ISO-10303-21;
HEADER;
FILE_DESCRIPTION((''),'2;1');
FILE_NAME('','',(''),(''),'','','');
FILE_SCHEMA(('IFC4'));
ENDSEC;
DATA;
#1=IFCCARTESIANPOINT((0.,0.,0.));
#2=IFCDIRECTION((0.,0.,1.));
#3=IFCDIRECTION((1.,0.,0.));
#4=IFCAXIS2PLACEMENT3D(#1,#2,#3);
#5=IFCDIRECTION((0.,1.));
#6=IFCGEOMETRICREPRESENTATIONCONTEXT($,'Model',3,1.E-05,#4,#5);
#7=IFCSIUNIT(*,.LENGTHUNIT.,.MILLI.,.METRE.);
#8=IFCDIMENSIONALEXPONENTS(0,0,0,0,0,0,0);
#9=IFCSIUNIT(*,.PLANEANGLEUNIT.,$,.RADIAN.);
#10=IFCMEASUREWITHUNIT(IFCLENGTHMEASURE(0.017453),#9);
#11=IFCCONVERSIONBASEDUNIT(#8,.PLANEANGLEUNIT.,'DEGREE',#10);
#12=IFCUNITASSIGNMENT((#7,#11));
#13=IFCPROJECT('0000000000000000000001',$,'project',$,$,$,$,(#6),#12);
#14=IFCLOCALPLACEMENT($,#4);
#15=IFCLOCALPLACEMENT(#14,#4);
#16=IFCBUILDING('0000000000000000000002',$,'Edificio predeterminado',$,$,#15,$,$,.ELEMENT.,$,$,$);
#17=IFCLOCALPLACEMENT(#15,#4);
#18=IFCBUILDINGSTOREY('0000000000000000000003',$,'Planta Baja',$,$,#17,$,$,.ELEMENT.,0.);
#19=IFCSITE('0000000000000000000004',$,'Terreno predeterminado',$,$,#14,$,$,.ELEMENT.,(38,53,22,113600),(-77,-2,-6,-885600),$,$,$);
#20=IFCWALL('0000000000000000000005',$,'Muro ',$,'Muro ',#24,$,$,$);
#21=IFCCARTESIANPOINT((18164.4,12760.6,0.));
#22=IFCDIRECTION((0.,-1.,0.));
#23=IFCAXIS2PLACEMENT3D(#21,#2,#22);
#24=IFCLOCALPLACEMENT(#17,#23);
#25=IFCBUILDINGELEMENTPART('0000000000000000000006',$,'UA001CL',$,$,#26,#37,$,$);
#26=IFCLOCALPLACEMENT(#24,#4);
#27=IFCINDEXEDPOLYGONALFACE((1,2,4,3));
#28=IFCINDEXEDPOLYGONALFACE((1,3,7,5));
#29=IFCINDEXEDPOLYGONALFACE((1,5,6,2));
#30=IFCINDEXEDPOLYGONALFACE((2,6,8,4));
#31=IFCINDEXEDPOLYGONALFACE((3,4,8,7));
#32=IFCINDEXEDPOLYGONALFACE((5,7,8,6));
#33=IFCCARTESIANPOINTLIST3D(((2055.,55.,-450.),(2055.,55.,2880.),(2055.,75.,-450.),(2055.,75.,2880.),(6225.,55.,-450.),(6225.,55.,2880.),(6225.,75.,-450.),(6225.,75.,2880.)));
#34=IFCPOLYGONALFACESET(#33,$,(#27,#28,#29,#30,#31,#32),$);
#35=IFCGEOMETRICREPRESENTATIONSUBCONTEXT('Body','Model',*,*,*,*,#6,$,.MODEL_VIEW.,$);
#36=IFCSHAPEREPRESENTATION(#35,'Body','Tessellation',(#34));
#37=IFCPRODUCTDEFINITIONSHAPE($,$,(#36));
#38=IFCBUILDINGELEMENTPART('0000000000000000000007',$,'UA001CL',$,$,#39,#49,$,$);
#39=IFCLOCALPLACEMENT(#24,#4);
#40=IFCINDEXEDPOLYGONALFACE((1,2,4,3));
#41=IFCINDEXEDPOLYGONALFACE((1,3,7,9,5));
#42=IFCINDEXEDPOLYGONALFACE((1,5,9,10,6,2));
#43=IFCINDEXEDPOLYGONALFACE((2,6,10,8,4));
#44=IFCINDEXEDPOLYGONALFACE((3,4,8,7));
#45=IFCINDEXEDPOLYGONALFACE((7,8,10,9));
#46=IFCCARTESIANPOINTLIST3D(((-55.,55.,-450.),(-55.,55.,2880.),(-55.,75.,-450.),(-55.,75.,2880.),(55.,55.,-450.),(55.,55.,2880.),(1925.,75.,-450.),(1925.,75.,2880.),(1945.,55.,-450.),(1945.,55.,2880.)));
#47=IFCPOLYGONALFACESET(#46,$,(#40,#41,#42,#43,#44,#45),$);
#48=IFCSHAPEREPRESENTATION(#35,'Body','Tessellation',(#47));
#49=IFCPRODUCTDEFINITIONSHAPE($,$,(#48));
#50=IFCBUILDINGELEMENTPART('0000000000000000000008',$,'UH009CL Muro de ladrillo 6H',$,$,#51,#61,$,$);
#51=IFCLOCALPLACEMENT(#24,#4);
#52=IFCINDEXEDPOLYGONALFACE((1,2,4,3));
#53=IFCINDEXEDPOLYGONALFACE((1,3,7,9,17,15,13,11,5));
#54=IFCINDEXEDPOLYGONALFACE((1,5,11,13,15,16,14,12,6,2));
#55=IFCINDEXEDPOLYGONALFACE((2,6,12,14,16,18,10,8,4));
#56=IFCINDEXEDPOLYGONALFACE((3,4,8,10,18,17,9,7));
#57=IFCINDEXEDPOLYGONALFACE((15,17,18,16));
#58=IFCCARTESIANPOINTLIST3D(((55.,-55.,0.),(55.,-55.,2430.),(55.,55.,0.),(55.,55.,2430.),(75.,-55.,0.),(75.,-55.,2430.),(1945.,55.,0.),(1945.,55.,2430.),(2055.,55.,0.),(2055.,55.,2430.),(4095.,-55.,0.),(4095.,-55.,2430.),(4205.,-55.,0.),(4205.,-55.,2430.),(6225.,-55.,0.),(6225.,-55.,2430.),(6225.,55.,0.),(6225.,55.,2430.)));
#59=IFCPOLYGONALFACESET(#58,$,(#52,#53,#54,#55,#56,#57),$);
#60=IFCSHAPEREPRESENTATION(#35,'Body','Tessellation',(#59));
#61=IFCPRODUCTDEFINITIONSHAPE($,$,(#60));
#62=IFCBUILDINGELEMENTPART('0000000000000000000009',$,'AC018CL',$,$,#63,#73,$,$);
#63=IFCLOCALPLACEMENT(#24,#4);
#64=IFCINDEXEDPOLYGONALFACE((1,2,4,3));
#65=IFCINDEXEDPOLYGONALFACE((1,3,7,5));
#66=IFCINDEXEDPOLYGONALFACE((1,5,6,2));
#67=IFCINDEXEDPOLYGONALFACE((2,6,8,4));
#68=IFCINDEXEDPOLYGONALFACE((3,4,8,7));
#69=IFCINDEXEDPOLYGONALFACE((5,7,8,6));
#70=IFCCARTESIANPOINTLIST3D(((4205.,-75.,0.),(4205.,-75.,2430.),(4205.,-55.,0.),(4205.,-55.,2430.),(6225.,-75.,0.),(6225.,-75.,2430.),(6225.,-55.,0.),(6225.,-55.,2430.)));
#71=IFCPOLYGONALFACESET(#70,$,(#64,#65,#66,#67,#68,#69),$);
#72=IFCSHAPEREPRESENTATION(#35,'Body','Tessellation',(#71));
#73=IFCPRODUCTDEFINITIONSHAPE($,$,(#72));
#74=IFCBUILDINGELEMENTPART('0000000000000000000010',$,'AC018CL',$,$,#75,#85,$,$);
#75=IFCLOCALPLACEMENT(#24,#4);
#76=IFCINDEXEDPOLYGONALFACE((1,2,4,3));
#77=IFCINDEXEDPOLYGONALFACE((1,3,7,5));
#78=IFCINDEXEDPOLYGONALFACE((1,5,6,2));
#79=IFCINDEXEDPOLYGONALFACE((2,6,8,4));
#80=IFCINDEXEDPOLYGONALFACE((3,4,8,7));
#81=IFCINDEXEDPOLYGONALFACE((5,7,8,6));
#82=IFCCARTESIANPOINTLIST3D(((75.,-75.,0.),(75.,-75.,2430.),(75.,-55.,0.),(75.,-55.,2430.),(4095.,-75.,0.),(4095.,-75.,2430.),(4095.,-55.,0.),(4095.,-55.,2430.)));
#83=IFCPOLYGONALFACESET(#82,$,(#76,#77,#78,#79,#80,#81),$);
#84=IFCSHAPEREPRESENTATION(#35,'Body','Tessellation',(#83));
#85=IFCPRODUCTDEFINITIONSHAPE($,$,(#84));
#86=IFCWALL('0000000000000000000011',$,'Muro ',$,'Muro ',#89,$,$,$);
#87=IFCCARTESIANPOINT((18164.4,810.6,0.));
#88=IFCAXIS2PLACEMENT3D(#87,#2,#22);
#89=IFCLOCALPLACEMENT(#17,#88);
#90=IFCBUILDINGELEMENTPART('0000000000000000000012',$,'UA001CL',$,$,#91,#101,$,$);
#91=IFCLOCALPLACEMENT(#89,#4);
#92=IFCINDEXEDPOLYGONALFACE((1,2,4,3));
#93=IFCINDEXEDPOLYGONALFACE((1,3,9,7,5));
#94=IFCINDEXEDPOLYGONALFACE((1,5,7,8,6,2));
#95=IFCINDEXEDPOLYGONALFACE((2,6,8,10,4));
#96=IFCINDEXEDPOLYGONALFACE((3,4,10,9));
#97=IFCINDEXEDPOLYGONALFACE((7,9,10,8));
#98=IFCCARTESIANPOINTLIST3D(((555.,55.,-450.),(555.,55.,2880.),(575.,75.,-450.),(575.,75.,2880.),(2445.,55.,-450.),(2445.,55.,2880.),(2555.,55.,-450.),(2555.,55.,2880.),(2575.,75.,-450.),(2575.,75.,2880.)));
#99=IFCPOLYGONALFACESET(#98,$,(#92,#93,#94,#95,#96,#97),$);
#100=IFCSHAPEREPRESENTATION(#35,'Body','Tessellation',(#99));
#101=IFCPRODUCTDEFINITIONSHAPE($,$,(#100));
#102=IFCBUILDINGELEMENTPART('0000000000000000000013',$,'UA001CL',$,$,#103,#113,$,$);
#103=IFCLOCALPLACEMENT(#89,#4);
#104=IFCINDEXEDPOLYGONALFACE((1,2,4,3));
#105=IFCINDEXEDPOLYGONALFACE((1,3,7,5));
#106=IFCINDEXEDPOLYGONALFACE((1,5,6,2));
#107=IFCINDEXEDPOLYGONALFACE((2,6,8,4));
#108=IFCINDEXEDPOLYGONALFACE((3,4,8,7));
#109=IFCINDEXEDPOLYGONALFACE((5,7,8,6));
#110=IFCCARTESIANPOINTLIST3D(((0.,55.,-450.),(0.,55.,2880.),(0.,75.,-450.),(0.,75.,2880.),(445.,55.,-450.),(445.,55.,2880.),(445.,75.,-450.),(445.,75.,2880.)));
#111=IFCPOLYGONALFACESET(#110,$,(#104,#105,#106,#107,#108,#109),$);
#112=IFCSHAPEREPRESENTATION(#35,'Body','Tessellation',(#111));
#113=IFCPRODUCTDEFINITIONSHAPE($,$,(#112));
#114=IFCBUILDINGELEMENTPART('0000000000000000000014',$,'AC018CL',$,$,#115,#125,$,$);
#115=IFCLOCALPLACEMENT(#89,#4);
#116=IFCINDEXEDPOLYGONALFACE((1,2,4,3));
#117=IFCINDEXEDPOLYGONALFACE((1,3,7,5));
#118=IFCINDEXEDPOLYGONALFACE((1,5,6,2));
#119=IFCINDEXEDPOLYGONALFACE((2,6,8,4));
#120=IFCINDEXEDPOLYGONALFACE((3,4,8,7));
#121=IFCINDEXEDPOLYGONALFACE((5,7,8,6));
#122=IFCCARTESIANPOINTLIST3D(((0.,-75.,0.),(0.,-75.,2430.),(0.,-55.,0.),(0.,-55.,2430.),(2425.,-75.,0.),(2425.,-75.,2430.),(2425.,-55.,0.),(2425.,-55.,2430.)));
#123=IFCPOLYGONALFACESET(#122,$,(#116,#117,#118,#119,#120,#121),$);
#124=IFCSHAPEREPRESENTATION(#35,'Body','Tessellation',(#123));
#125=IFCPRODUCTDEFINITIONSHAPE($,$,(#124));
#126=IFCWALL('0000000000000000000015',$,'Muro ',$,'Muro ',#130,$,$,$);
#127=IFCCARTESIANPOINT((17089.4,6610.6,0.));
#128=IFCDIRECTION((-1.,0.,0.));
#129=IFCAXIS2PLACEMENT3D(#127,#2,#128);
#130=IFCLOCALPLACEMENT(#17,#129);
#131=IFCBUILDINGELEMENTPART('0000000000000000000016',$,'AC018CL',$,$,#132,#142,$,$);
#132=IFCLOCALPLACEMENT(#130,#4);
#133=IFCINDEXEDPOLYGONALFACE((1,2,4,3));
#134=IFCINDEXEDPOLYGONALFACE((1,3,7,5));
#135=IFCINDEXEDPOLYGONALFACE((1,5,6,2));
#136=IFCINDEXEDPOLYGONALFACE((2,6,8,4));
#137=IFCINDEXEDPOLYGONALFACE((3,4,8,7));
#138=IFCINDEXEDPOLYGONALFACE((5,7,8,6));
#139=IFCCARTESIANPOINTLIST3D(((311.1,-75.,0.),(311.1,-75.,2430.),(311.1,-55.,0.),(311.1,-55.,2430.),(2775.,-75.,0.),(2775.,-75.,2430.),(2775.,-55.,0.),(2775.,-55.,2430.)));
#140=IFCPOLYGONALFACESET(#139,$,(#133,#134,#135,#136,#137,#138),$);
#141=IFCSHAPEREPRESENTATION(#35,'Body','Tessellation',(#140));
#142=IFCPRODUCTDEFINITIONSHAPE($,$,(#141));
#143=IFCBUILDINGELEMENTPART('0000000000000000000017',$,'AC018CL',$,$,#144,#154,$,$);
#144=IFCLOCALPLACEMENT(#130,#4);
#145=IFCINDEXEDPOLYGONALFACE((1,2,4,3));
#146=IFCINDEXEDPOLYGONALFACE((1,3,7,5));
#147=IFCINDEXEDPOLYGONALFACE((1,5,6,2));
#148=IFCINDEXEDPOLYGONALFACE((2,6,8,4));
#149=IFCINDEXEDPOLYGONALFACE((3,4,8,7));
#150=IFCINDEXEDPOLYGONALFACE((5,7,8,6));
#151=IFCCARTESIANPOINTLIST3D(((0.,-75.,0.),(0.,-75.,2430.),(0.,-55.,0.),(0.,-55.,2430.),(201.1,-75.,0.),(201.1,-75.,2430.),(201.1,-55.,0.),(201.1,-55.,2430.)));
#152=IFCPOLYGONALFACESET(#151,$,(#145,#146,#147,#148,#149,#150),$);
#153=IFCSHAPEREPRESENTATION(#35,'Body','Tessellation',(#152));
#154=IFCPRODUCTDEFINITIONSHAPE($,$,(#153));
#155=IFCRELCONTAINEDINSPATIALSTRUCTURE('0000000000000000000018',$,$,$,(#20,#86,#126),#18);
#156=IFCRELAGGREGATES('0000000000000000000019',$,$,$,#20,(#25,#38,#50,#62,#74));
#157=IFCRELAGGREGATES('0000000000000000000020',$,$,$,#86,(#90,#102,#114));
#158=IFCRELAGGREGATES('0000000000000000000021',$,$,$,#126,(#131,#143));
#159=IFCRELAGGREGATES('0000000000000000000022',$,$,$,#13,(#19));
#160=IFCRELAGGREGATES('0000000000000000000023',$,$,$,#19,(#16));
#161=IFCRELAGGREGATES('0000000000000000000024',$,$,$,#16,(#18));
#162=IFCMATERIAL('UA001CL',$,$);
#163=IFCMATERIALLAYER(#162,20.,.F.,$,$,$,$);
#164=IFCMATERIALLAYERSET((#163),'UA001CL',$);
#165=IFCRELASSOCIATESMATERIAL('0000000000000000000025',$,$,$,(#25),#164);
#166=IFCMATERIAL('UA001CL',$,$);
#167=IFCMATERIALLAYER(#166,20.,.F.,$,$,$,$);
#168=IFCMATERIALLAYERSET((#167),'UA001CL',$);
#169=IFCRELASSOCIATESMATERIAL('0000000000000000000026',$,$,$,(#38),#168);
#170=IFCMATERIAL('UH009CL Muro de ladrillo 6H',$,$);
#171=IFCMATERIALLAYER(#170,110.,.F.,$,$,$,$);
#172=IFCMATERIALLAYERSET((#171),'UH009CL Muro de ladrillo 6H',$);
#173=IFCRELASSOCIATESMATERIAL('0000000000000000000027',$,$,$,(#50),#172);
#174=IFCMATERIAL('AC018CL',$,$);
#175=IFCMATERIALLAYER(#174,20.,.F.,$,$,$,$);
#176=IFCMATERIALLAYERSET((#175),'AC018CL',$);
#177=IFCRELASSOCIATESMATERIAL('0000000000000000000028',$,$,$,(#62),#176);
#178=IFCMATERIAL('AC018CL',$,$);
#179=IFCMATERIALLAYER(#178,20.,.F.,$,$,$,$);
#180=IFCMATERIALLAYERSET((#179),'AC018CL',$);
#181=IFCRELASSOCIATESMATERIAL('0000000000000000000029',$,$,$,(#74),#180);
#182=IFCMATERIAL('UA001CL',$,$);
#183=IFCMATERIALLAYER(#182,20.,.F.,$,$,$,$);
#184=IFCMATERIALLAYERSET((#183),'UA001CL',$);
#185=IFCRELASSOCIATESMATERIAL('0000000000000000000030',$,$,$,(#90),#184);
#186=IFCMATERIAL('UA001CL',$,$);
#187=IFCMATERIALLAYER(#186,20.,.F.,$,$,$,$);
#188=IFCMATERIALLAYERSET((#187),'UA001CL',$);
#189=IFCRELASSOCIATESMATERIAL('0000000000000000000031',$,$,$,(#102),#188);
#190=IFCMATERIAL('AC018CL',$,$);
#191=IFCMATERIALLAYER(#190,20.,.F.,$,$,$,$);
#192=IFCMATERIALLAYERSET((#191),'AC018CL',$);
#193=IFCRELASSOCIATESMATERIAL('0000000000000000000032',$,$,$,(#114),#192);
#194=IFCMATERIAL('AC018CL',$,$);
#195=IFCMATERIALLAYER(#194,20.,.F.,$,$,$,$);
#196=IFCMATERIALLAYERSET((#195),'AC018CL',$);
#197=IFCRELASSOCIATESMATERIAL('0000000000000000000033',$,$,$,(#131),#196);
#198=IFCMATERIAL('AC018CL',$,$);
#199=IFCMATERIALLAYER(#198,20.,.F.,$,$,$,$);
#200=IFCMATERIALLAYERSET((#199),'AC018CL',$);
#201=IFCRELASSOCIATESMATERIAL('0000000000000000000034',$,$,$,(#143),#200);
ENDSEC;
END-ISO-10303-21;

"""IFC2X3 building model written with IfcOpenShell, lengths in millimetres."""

from ifc_helpers import new_model, entity, si_unit, converted_unit, direction, frame, origin_with_axes, place, context, subcontext, project, spatial, polyline, outline, extrude, material, layer, layer_set, layer_usage, element, aggregate, save


model = new_model("IFC2X3")

# Units and contexts
model_context = context("Model", 3, precision=1e-05, world=origin_with_axes(), true_north=direction((0.0, 1.0)))
body_context = subcontext(model_context, "Body", "Model", "MODEL_VIEW")
ifc_project = project(units=[si_unit("LENGTHUNIT", "METRE", prefix="MILLI"), converted_unit("PLANEANGLEUNIT", "DEGREE", entity("IfcLengthMeasure", 0.017453), si_unit("PLANEANGLEUNIT", "RADIAN"), dimensions=[0, 0, 0, 0, 0, 0, 0])], contexts=[model_context])

# Site, building, storey
site_placement = place(None, origin_with_axes())
site = spatial("IfcSite", under=ifc_project, at=site_placement, Name="Terreno predeterminado", CompositionType="ELEMENT", RefLatitude=(38, 53, 22, 113600), RefLongitude=(-77, -2, -6, -885600))
building_placement = place(site_placement, origin_with_axes())
building = spatial("IfcBuilding", under=site, at=building_placement, Name="Edificio predeterminado", CompositionType="ELEMENT")
storey_placement = place(building_placement, origin_with_axes())
storey = spatial("IfcBuildingStorey", under=building, at=storey_placement, Name="Planta Baja", CompositionType="ELEMENT", Elevation=0.0)

# Walls, building element parts
wall_1_placement = place(storey_placement, frame((18164.4, 12760.6, 0.0), z_axis=(0.0, 0.0, 1.0), x_axis=(0.0, -1.0, 0.0)))
wall_1 = element("IfcWall", 1, at=wall_1_placement, inside=storey, Name="Muro ", ObjectType="Muro ")
ifc_material_1 = material(Name="UA001CL")
ifc_layer_1 = layer(ifc_material_1, 20.0, ventilated=False)
ifc_layer_set_1 = layer_set([ifc_layer_1], Name="UA001CL")
ifc_layer_usage_1 = layer_usage(ifc_layer_set_1, "AXIS2", "NEGATIVE", -75.0)
building_element_part_1_placement = place(wall_1_placement, origin_with_axes())
building_element_part_1 = element("IfcBuildingElementPart", 2, at=building_element_part_1_placement, material=ifc_layer_usage_1, Name="UA001CL", context=body_context, shape_type="SweptSolid", body=[
    extrude(outline(polyline([(6225.0, 75.0), (6225.0, 55.0), (2055.0, 55.0), (2055.0, 75.0), (6225.0, 75.0)])), frame((0.0, 0.0, -450.0), z_axis=(0.0, 0.0, 1.0), x_axis=(1.0, 0.0, 0.0)), (0.0, 0.0, 1.0), 3330.0),
])
ifc_material_2 = material(Name="UA001CL")
ifc_layer_2 = layer(ifc_material_2, 20.0, ventilated=False)
ifc_layer_set_2 = layer_set([ifc_layer_2], Name="UA001CL")
ifc_layer_usage_2 = layer_usage(ifc_layer_set_2, "AXIS2", "NEGATIVE", -75.0)
building_element_part_2_placement = place(wall_1_placement, origin_with_axes())
building_element_part_2 = element("IfcBuildingElementPart", 3, at=building_element_part_2_placement, material=ifc_layer_usage_2, Name="UA001CL", context=body_context, shape_type="SweptSolid", body=[
    extrude(outline(polyline([(1925.0, 75.0), (1945.0, 55.0), (55.0, 55.0), (-55.0, 55.0), (-55.0, 75.0), (1925.0, 75.0)])), frame((0.0, 0.0, -450.0), z_axis=(0.0, 0.0, 1.0), x_axis=(1.0, 0.0, 0.0)), (0.0, 0.0, 1.0), 3330.0),
])
ifc_material_3 = material(Name="UH009CL Muro de ladrillo 6H")
ifc_layer_3 = layer(ifc_material_3, 110.0, ventilated=False)
ifc_layer_set_3 = layer_set([ifc_layer_3], Name="UH009CL Muro de ladrillo 6H")
ifc_layer_usage_3 = layer_usage(ifc_layer_set_3, "AXIS2", "NEGATIVE", -55.0)
building_element_part_3_placement = place(wall_1_placement, origin_with_axes())
building_element_part_3 = element("IfcBuildingElementPart", 4, at=building_element_part_3_placement, material=ifc_layer_usage_3, Name="UH009CL Muro de ladrillo 6H", context=body_context, shape_type="SweptSolid", body=[
    extrude(outline(polyline([(6225.0, 55.0), (6225.0, -55.0), (4205.0, -55.0), (4095.0, -55.0), (75.0, -55.0), (55.0, -55.0), (55.0, 55.0), (1945.0, 55.0), (2055.0, 55.0), (6225.0, 55.0)])), origin_with_axes(), (0.0, 0.0, 1.0), 2430.0),
])
ifc_material_4 = material(Name="AC018CL")
ifc_layer_4 = layer(ifc_material_4, 20.0, ventilated=False)
ifc_layer_set_4 = layer_set([ifc_layer_4], Name="AC018CL")
ifc_layer_usage_4 = layer_usage(ifc_layer_set_4, "AXIS2", "NEGATIVE", 55.0)
building_element_part_4_placement = place(wall_1_placement, origin_with_axes())
building_element_part_4 = element("IfcBuildingElementPart", 5, at=building_element_part_4_placement, material=ifc_layer_usage_4, Name="AC018CL", context=body_context, shape_type="SweptSolid", body=[
    extrude(outline(polyline([(6225.0, -55.0), (6225.0, -75.0), (4205.0, -75.0), (4205.0, -55.0), (6225.0, -55.0)])), origin_with_axes(), (0.0, 0.0, 1.0), 2430.0),
])
ifc_material_5 = material(Name="AC018CL")
ifc_layer_5 = layer(ifc_material_5, 20.0, ventilated=False)
ifc_layer_set_5 = layer_set([ifc_layer_5], Name="AC018CL")
ifc_layer_usage_5 = layer_usage(ifc_layer_set_5, "AXIS2", "NEGATIVE", 55.0)
building_element_part_5_placement = place(wall_1_placement, origin_with_axes())
building_element_part_5 = element("IfcBuildingElementPart", 6, at=building_element_part_5_placement, material=ifc_layer_usage_5, Name="AC018CL", context=body_context, shape_type="SweptSolid", body=[
    extrude(outline(polyline([(4095.0, -55.0), (4095.0, -75.0), (75.0, -75.0), (75.0, -55.0), (4095.0, -55.0)])), origin_with_axes(), (0.0, 0.0, 1.0), 2430.0),
])
aggregate(wall_1, [building_element_part_1, building_element_part_2, building_element_part_3, building_element_part_4, building_element_part_5])
wall_2_placement = place(storey_placement, frame((18164.4, 810.6, 0.0), z_axis=(0.0, 0.0, 1.0), x_axis=(0.0, -1.0, 0.0)))
wall_2 = element("IfcWall", 7, at=wall_2_placement, inside=storey, Name="Muro ", ObjectType="Muro ")
ifc_material_6 = material(Name="UA001CL")
ifc_layer_6 = layer(ifc_material_6, 20.0, ventilated=False)
ifc_layer_set_6 = layer_set([ifc_layer_6], Name="UA001CL")
ifc_layer_usage_6 = layer_usage(ifc_layer_set_6, "AXIS2", "NEGATIVE", -75.0)
building_element_part_6_placement = place(wall_2_placement, origin_with_axes())
building_element_part_6 = element("IfcBuildingElementPart", 8, at=building_element_part_6_placement, material=ifc_layer_usage_6, Name="UA001CL", context=body_context, shape_type="SweptSolid", body=[
    extrude(outline(polyline([(2575.0, 75.0), (2555.0, 55.0), (2445.0, 55.0), (555.0, 55.0), (575.0, 75.0), (2575.0, 75.0)])), frame((0.0, 0.0, -450.0), z_axis=(0.0, 0.0, 1.0), x_axis=(1.0, 0.0, 0.0)), (0.0, 0.0, 1.0), 3330.0),
])
ifc_material_7 = material(Name="UA001CL")
ifc_layer_7 = layer(ifc_material_7, 20.0, ventilated=False)
ifc_layer_set_7 = layer_set([ifc_layer_7], Name="UA001CL")
ifc_layer_usage_7 = layer_usage(ifc_layer_set_7, "AXIS2", "NEGATIVE", -75.0)
building_element_part_7_placement = place(wall_2_placement, origin_with_axes())
building_element_part_7 = element("IfcBuildingElementPart", 9, at=building_element_part_7_placement, material=ifc_layer_usage_7, Name="UA001CL", context=body_context, shape_type="SweptSolid", body=[
    extrude(outline(polyline([(445.0, 75.0), (445.0, 55.0), (0.0, 55.0), (0.0, 75.0), (445.0, 75.0)])), frame((0.0, 0.0, -450.0), z_axis=(0.0, 0.0, 1.0), x_axis=(1.0, 0.0, 0.0)), (0.0, 0.0, 1.0), 3330.0),
])
ifc_material_8 = material(Name="AC018CL")
ifc_layer_8 = layer(ifc_material_8, 20.0, ventilated=False)
ifc_layer_set_8 = layer_set([ifc_layer_8], Name="AC018CL")
ifc_layer_usage_8 = layer_usage(ifc_layer_set_8, "AXIS2", "NEGATIVE", 55.0)
building_element_part_8_placement = place(wall_2_placement, origin_with_axes())
building_element_part_8 = element("IfcBuildingElementPart", 10, at=building_element_part_8_placement, material=ifc_layer_usage_8, Name="AC018CL", context=body_context, shape_type="SweptSolid", body=[
    extrude(outline(polyline([(2425.0, -55.0), (2425.0, -75.0), (0.0, -75.0), (0.0, -55.0), (2425.0, -55.0)])), origin_with_axes(), (0.0, 0.0, 1.0), 2430.0),
])
aggregate(wall_2, [building_element_part_6, building_element_part_7, building_element_part_8])
wall_3_placement = place(storey_placement, frame((17089.4, 6610.6, 0.0), z_axis=(0.0, 0.0, 1.0), x_axis=(-1.0, 0.0, 0.0)))
wall_3 = element("IfcWall", 11, at=wall_3_placement, inside=storey, Name="Muro ", ObjectType="Muro ")
ifc_material_9 = material(Name="AC018CL")
ifc_layer_9 = layer(ifc_material_9, 20.0, ventilated=False)
ifc_layer_set_9 = layer_set([ifc_layer_9], Name="AC018CL")
ifc_layer_usage_9 = layer_usage(ifc_layer_set_9, "AXIS2", "NEGATIVE", 55.0)
building_element_part_9_placement = place(wall_3_placement, origin_with_axes())
building_element_part_9 = element("IfcBuildingElementPart", 12, at=building_element_part_9_placement, material=ifc_layer_usage_9, Name="AC018CL", context=body_context, shape_type="SweptSolid", body=[
    extrude(outline(polyline([(2775.0, -55.0), (2775.0, -75.0), (311.1, -75.0), (311.1, -55.0), (2775.0, -55.0)])), origin_with_axes(), (0.0, 0.0, 1.0), 2430.0),
])
ifc_material_10 = material(Name="AC018CL")
ifc_layer_10 = layer(ifc_material_10, 20.0, ventilated=False)
ifc_layer_set_10 = layer_set([ifc_layer_10], Name="AC018CL")
ifc_layer_usage_10 = layer_usage(ifc_layer_set_10, "AXIS2", "NEGATIVE", 55.0)
building_element_part_10_placement = place(wall_3_placement, origin_with_axes())
building_element_part_10 = element("IfcBuildingElementPart", 13, at=building_element_part_10_placement, material=ifc_layer_usage_10, Name="AC018CL", context=body_context, shape_type="SweptSolid", body=[
    extrude(outline(polyline([(201.1, -55.0), (201.1, -75.0), (0.0, -75.0), (0.0, -55.0), (201.1, -55.0)])), origin_with_axes(), (0.0, 0.0, 1.0), 2430.0),
])
aggregate(wall_3, [building_element_part_9, building_element_part_10])

save(model, "model.ifc")
